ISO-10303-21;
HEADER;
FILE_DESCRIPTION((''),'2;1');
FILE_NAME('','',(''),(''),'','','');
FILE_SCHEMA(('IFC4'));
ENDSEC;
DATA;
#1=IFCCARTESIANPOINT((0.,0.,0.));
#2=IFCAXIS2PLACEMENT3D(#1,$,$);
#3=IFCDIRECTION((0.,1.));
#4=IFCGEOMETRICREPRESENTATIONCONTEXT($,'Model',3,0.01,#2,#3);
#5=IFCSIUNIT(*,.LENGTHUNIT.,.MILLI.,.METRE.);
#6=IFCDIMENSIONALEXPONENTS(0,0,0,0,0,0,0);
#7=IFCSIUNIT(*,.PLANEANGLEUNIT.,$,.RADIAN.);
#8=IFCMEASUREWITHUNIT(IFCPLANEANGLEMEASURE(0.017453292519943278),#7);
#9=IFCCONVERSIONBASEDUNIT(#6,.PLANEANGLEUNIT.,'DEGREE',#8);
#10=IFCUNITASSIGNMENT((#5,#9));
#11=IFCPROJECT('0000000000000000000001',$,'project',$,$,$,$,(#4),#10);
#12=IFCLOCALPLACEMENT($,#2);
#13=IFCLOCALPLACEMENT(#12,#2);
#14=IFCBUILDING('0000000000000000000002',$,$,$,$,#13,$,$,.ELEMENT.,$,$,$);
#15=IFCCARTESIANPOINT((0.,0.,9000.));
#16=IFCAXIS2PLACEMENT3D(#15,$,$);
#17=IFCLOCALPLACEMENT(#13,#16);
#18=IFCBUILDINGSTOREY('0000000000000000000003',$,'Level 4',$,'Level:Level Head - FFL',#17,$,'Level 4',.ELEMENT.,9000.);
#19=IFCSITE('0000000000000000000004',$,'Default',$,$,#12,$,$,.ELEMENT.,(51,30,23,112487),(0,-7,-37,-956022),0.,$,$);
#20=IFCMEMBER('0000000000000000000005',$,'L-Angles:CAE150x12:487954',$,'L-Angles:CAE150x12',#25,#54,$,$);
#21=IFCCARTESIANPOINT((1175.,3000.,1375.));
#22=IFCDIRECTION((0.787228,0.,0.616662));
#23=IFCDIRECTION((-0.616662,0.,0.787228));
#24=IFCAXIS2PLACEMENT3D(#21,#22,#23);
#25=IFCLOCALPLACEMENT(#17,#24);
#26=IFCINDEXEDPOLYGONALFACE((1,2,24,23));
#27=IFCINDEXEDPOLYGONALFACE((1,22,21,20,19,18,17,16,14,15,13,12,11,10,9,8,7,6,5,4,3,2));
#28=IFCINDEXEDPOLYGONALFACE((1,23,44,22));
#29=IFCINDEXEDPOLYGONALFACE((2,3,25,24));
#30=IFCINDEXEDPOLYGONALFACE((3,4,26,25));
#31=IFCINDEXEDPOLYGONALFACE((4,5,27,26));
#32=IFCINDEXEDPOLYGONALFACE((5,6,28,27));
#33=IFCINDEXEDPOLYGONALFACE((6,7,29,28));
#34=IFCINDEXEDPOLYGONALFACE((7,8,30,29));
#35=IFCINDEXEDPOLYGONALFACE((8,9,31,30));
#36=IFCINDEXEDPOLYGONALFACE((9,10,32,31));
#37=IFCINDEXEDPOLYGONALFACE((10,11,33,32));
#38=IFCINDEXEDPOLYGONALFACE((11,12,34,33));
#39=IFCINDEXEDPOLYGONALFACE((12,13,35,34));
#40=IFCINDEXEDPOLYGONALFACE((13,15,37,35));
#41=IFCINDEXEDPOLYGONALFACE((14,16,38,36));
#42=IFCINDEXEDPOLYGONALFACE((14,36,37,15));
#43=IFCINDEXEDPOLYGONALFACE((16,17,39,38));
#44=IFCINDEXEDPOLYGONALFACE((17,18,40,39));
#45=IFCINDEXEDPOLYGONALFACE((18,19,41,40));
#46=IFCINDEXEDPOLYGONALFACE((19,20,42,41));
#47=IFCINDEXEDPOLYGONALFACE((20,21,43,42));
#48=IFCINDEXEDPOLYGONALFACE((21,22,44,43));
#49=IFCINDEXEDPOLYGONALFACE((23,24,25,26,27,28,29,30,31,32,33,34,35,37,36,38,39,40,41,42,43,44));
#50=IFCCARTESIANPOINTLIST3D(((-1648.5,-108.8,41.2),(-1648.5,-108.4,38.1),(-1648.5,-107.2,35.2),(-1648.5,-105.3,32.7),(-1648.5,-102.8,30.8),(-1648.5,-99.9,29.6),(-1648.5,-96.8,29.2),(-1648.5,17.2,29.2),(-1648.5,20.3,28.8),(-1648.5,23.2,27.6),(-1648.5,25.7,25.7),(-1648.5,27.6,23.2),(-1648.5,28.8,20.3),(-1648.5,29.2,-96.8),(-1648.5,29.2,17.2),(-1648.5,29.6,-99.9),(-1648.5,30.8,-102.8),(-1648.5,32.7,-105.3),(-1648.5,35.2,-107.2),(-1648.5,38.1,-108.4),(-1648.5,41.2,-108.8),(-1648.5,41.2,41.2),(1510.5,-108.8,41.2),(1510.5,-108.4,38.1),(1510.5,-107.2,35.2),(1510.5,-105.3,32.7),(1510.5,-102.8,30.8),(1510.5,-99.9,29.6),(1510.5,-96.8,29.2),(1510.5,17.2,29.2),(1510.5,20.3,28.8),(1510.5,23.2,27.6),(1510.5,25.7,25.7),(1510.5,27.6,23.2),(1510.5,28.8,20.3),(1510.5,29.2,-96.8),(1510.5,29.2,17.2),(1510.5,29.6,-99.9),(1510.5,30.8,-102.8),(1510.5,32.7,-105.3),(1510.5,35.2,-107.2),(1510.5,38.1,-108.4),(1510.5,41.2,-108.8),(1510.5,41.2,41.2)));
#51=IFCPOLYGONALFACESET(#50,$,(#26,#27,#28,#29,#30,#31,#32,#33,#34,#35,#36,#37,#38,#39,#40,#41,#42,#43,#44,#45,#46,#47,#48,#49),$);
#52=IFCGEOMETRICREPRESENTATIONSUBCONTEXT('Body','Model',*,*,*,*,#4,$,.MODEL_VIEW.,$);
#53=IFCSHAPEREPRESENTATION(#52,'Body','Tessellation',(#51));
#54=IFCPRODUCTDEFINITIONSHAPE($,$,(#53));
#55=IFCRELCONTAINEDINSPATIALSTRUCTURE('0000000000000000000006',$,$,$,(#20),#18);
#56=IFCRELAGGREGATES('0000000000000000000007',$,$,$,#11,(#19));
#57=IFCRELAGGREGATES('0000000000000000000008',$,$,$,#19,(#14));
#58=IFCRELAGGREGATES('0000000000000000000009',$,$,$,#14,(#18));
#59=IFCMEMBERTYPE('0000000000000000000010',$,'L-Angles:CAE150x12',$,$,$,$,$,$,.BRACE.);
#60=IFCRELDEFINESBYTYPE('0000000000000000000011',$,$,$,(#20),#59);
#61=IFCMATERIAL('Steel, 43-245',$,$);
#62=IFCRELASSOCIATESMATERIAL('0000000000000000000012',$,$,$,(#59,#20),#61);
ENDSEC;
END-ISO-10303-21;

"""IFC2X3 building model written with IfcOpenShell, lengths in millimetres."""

from ifc_helpers import new_model, entity, si_unit, converted_unit, direction, frame, frame_2d, origin, place, context, subcontext, project, spatial, polyline, circle_curve, parameter, trimmed, segment, composite_curve, outline, extrude, source, transform, mapped, material, type_object, type_shapes, element, save


model = new_model("IFC2X3")

# Units and contexts
model_context = context("Model", 3, precision=0.01, world=origin(), true_north=direction((0.0, 1.0)))
body_context = subcontext(model_context, "Body", "Model", "MODEL_VIEW")
ifc_project = project(units=[si_unit("LENGTHUNIT", "METRE", prefix="MILLI"), converted_unit("PLANEANGLEUNIT", "DEGREE", entity("IfcPlaneAngleMeasure", 0.017453292519943278), si_unit("PLANEANGLEUNIT", "RADIAN"), dimensions=[0, 0, 0, 0, 0, 0, 0])], contexts=[model_context])

# Site, building, storey
site_placement = place(None, origin())
site = spatial("IfcSite", under=ifc_project, at=site_placement, Name="Default", CompositionType="ELEMENT", RefLatitude=(51, 30, 23, 112487), RefLongitude=(0, -7, -37, -956022), RefElevation=0.0)
building_placement = place(site_placement, origin())
building = spatial("IfcBuilding", under=site, at=building_placement, CompositionType="ELEMENT")
storey_placement = place(building_placement, frame((0.0, 0.0, 9000.0)))
storey = spatial("IfcBuildingStorey", under=building, at=storey_placement, Name="Level 4", ObjectType="Level:Level Head - FFL", LongName="Level 4", CompositionType="ELEMENT", Elevation=9000.0)

# Shared definitions
ifc_material = material(Name="Steel, 43-245")

# Member
member_type_1 = type_object("IfcMemberType", Name="L-Angles:CAE150x12", PredefinedType="BRACE", material=ifc_material)
shared_shape_1 = source(origin(), body_context, "Body", "SweptSolid", [
    extrude(outline(composite_curve([segment(polyline([(-102.0, -48.0), (48.0, -48.0)]), True, "CONTINUOUS"), segment(polyline([(48.0, -48.0), (48.0, 102.0)]), True, "CONTINUOUS"), segment(trimmed(circle_curve(frame_2d((48.0, 90.0), x_axis=(0.0, 1.0)), 12.0), [parameter(0.0)], [parameter(90.0)], True, "PARAMETER"), True, "CONTINUOUS"), segment(polyline([(36.0, 90.0), (36.0, -24.0)]), True, "CONTINUOUS"), segment(trimmed(circle_curve(frame_2d((24.0, -24.0), x_axis=(1.0, 0.0)), 12.0), [parameter(270.0)], [parameter(0.0)], True, "PARAMETER"), False, "CONTINUOUS"), segment(polyline([(24.0, -36.0), (-90.0, -36.0)]), True, "CONTINUOUS"), segment(trimmed(circle_curve(frame_2d((-90.0, -48.0), x_axis=(0.0, 1.0)), 12.0), [parameter(0.0)], [parameter(90.0)], True, "PARAMETER"), True, "CONTINUOUS")], self_intersect=False)), frame((-1648.5, -6.8, -6.8), z_axis=(1.0, 0.0, 0.0), x_axis=(0.0, 0.0, 1.0)), (0.0, 0.0, 1.0), 3159.0),
])
type_shapes(member_type_1, [shared_shape_1])
for number, where, z_axis, x_axis, name in (
    (1, (1175.0, 3000.0, 1375.0), (0.787228, 0.0, 0.616662), (-0.616662, 0.0, 0.787228), "L-Angles:CAE150x12:487954"),
):
    element("IfcMember", number, at=place(storey_placement, frame(where, z_axis=z_axis, x_axis=x_axis)), inside=storey, type_object=member_type_1, material=ifc_material, Name=name, ObjectType="L-Angles:CAE150x12", context=body_context, shape_type="MappedRepresentation", body=[
        mapped(shared_shape_1, transform((0.0, 0.0, 0.0), scale=1.0)),
    ])

save(model, "model.ifc")
